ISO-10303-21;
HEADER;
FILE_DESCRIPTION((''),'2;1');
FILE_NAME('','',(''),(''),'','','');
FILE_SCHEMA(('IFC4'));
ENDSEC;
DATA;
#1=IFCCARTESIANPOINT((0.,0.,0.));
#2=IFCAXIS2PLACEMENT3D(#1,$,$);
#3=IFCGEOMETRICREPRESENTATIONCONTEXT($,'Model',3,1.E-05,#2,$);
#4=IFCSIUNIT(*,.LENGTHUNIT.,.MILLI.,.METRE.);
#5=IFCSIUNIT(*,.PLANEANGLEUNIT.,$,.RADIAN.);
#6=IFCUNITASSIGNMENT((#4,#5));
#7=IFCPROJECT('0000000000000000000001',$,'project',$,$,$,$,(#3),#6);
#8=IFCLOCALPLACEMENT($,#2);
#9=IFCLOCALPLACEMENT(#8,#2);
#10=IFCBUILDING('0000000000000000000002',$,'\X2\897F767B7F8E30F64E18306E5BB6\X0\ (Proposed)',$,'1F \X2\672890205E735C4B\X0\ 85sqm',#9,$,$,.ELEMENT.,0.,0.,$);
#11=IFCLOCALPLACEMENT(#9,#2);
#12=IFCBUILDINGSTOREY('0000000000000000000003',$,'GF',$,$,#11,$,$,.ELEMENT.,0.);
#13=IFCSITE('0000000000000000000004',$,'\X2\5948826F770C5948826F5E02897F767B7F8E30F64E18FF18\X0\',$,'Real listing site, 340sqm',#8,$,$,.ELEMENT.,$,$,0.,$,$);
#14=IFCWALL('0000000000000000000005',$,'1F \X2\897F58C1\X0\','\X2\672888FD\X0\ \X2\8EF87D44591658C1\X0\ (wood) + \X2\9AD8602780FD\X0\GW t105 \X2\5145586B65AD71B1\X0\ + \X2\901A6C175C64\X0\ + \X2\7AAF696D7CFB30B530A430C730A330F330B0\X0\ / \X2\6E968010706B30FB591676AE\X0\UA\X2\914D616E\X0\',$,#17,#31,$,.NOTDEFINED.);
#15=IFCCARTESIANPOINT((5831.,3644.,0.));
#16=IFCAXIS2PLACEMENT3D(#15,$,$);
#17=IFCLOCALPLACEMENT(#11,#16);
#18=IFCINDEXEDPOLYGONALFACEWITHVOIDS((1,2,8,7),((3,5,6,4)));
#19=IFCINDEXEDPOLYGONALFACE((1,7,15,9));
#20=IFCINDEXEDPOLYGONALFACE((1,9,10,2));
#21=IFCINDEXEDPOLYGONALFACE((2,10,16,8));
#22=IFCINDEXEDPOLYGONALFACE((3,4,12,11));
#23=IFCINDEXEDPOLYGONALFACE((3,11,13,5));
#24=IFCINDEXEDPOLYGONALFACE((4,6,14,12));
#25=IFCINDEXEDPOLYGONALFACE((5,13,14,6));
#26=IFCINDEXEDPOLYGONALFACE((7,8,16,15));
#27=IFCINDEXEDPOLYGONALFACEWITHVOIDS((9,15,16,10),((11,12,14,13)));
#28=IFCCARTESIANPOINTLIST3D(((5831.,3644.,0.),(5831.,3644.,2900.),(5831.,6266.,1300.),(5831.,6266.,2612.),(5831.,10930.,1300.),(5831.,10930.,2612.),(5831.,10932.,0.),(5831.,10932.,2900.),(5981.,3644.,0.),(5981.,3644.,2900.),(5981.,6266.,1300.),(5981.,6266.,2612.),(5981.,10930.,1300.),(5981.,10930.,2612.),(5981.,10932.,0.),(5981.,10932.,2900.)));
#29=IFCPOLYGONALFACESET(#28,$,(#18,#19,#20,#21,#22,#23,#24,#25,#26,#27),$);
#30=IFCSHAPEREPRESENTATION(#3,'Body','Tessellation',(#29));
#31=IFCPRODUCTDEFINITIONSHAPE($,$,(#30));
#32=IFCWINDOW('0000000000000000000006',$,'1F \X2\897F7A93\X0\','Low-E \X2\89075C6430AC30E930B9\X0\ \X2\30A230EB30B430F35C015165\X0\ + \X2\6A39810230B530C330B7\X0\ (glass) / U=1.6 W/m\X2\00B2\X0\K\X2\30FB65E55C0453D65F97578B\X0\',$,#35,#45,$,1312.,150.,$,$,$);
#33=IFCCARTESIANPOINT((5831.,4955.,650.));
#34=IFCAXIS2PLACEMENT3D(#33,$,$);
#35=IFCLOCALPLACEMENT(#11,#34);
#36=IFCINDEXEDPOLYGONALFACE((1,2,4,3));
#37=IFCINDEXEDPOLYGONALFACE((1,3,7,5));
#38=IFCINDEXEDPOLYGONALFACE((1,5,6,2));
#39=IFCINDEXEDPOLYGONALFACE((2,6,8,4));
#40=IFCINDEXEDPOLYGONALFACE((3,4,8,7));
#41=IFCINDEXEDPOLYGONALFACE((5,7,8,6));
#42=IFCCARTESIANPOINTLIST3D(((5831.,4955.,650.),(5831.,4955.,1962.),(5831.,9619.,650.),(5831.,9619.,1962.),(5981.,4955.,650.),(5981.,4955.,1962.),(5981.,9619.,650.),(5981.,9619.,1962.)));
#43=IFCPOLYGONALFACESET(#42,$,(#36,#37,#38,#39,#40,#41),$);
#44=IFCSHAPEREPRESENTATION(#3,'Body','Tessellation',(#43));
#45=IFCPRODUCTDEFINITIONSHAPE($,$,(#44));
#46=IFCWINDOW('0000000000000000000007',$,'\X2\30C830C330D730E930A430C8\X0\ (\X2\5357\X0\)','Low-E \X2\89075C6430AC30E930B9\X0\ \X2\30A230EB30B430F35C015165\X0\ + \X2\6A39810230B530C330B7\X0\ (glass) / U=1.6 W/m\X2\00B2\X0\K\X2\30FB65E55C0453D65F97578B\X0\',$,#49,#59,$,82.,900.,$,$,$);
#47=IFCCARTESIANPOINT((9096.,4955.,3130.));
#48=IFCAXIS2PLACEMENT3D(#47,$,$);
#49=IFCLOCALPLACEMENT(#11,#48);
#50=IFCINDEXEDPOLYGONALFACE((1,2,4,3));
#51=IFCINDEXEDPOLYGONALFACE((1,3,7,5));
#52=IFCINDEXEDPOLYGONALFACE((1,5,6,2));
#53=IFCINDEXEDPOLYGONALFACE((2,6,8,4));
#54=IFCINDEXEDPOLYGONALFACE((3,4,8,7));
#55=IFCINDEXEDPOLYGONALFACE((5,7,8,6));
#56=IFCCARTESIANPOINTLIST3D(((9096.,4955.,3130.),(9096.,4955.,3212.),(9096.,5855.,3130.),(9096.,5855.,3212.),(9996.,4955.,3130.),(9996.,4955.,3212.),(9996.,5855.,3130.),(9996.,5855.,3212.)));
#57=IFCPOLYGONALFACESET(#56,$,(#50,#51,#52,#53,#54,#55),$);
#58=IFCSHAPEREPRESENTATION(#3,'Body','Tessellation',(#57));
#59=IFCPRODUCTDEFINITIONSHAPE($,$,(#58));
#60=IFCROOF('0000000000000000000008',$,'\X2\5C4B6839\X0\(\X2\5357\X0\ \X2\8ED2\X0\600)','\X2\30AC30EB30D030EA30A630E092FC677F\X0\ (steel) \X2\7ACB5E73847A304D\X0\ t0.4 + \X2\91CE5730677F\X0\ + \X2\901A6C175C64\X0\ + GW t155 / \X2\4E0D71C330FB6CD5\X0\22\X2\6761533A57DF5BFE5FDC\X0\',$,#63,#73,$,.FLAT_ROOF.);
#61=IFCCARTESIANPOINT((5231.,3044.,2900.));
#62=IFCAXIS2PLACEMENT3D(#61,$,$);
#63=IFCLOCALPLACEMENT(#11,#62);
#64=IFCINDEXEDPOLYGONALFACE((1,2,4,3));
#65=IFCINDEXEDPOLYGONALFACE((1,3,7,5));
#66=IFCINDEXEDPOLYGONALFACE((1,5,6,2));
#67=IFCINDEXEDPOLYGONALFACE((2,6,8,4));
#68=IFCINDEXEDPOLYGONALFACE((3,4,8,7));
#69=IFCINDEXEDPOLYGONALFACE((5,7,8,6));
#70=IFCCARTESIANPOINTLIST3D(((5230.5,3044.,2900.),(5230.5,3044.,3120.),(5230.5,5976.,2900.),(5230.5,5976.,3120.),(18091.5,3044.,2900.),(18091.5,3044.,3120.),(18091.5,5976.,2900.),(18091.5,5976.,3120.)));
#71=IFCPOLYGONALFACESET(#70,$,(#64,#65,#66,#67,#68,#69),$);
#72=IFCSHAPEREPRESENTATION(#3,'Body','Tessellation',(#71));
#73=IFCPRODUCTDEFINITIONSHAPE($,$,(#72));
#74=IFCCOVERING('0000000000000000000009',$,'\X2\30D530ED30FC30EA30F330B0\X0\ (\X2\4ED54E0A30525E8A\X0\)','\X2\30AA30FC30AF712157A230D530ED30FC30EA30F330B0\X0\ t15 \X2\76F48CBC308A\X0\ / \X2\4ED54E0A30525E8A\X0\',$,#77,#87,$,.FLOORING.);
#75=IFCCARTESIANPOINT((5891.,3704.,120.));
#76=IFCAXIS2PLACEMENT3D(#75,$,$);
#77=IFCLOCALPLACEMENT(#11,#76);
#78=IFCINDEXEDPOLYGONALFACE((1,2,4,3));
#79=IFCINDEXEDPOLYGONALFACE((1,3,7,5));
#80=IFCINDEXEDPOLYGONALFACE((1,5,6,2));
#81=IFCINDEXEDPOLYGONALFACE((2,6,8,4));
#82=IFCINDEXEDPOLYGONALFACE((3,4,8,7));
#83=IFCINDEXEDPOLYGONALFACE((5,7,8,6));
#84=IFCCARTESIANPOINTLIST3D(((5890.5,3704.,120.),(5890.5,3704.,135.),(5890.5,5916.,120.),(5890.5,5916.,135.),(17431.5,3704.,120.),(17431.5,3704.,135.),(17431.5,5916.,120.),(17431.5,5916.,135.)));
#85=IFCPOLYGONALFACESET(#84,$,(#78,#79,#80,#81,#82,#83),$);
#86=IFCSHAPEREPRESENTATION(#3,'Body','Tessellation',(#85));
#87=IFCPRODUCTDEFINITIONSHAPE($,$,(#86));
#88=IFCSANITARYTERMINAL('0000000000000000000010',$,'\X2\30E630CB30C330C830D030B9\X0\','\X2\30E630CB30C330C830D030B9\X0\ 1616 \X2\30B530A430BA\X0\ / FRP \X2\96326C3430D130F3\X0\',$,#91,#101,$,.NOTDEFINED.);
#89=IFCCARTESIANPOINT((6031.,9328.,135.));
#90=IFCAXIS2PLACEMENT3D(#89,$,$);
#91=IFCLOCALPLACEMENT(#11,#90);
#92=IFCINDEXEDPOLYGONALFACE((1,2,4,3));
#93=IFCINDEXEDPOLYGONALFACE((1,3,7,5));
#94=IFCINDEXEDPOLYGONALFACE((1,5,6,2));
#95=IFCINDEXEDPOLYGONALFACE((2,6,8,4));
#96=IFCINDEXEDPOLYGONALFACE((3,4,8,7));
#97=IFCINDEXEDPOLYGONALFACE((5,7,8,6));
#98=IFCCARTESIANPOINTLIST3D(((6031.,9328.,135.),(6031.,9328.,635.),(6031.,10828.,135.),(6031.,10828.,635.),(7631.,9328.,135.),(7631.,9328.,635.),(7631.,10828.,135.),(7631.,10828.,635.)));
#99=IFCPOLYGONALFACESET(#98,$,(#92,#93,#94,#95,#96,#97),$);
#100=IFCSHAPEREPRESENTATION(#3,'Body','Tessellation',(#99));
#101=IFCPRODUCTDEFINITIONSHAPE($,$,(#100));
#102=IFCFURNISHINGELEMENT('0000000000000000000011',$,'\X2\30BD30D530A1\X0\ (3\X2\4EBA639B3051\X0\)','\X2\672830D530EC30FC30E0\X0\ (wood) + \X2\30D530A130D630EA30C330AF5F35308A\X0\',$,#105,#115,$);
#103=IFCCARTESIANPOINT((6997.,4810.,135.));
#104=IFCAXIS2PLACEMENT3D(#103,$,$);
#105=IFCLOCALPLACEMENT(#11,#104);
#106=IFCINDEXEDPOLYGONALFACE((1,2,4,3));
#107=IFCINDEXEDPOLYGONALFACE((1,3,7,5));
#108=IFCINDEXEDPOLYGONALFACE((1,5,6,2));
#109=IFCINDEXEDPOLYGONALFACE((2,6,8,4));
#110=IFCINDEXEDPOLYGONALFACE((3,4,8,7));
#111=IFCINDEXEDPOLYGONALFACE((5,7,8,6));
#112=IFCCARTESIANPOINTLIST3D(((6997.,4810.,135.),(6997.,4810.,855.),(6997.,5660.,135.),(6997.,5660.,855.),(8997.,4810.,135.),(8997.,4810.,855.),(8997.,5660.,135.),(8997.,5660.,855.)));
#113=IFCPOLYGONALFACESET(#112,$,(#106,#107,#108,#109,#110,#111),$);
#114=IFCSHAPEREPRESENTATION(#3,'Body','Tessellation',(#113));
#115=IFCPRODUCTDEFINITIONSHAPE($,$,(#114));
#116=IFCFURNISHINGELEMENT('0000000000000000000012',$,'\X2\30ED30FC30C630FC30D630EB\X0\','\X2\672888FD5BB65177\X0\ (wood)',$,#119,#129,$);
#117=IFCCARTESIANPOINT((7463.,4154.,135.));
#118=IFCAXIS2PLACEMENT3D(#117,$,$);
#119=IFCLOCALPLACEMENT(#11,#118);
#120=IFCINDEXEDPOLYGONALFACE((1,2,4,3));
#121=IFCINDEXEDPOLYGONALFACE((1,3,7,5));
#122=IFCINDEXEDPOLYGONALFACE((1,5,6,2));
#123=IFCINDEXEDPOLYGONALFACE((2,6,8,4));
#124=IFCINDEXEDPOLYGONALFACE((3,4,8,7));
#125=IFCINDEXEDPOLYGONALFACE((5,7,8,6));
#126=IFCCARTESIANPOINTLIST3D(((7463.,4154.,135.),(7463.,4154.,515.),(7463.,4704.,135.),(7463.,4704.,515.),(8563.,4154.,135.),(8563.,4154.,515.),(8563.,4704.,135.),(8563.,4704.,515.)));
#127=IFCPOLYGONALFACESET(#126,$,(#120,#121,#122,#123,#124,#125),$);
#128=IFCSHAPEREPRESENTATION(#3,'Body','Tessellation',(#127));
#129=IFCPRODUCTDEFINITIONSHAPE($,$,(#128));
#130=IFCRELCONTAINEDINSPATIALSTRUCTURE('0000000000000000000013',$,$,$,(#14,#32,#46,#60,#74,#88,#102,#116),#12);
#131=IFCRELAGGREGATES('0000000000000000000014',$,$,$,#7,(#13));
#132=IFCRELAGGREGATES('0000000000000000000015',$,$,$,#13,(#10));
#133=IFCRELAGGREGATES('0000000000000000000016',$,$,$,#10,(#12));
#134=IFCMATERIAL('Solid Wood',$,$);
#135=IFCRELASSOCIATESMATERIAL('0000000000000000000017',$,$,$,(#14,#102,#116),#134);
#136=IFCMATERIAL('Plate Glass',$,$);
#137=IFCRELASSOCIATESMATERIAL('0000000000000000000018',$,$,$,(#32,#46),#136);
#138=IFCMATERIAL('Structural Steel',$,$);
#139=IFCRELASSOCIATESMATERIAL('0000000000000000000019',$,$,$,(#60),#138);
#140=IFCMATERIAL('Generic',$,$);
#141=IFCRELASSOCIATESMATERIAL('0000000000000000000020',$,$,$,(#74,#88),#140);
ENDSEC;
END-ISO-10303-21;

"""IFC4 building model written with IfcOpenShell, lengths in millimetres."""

from ifc_helpers import new_model, si_unit, frame, frame_2d, origin, place, context, project, spatial, rectangle, extrude, material, element, fill, save


model = new_model("IFC4")

# Units and contexts
model_context = context("Model", 3, precision=1e-05, world=origin())
ifc_project = project(units=[si_unit("LENGTHUNIT", "METRE", prefix="MILLI"), si_unit("PLANEANGLEUNIT", "RADIAN")], contexts=[model_context])

# Site, building, storey
site_placement = place(None, origin())
site = spatial("IfcSite", under=ifc_project, at=site_placement, Name="奈良県奈良市西登美ヶ丘８", ObjectType="Real listing site, 340sqm", CompositionType="ELEMENT", RefElevation=0.0)
building_placement = place(site_placement, origin())
building = spatial("IfcBuilding", under=site, at=building_placement, Name="西登美ヶ丘の家 (Proposed)", ObjectType="1F 木造平屋 85sqm", CompositionType="ELEMENT", ElevationOfRefHeight=0.0, ElevationOfTerrain=0.0)
storey_placement = place(building_placement, origin())
storey = spatial("IfcBuildingStorey", under=building, at=storey_placement, Name="GF", CompositionType="ELEMENT", Elevation=0.0)

# Shared definitions
ifc_material_1 = material(Name="Solid Wood")

# Shared definitions
ifc_material_2 = material(Name="Plate Glass")

# Wall, opening, window
wall_1_placement = place(storey_placement, frame((5831.0, 3644.0, 0.0)))
wall_1 = element("IfcWall", 1, at=wall_1_placement, inside=storey, material=ifc_material_1, Name="1F 西壁", Description="木製 軸組外壁 (wood) + 高性能GW t105 充填断熱 + 通気層 + 窯業系サイディング / 準耐火・外皮UA配慮", PredefinedType="NOTDEFINED", context=model_context, shape_type="SweptSolid", body=[
    extrude(rectangle(XDim=150.0, YDim=7288.0, at=frame_2d((75.0, 3644.0))), frame((5831.0, 3644.0, 0.0)), (0.0, 0.0, 1.0), 2900.0),
])
opening_1_placement = place(storey_placement, frame((5831.0, 4955.0, 650.0)))
opening_1 = element("IfcOpeningElement", 2, at=opening_1_placement, cuts=wall_1, PredefinedType="NOTDEFINED", context=model_context, shape_type="SweptSolid", body=[
    extrude(rectangle(XDim=150.0, YDim=4664.0, at=frame_2d((75.0, 2332.0))), frame((5831.0, 4955.0, 650.0)), (0.0, 0.0, 1.0), 1312.0),
])
window_1_placement = place(storey_placement, frame((5831.0, 4955.0, 650.0)))
window_1 = element("IfcWindow", 3, at=window_1_placement, inside=storey, material=ifc_material_2, Name="1F 西窓", Description="Low-E 複層ガラス アルゴン封入 + 樹脂サッシ (glass) / U=1.6 W/m²K・日射取得型", OverallHeight=1312.0, OverallWidth=150.0, context=model_context, shape_type="SweptSolid", body=[
    extrude(rectangle(XDim=150.0, YDim=4664.0, at=frame_2d((75.0, 2332.0))), frame((5831.0, 4955.0, 650.0)), (0.0, 0.0, 1.0), 1312.0),
])
fill(opening_1, window_1)

# Window
window_2_placement = place(storey_placement, frame((9096.0, 4955.0, 3130.0)))
element("IfcWindow", 4, at=window_2_placement, inside=storey, material=ifc_material_2, Name="トップライト (南)", Description="Low-E 複層ガラス アルゴン封入 + 樹脂サッシ (glass) / U=1.6 W/m²K・日射取得型", OverallHeight=82.0, OverallWidth=900.0, context=model_context, shape_type="SweptSolid", body=[
    extrude(rectangle(XDim=900.0, YDim=900.0, at=frame_2d((450.0, 450.0))), frame((9096.0, 4955.0, 3130.0)), (0.0, 0.0, 1.0), 82.0),
])

# Roof
ifc_material_3 = material(Name="Structural Steel")
roof_1_placement = place(storey_placement, frame((5231.0, 3044.0, 2900.0)))
element("IfcRoof", 5, at=roof_1_placement, inside=storey, material=ifc_material_3, Name="屋根(南 軒600)", Description="ガルバリウム鋼板 (steel) 立平葺き t0.4 + 野地板 + 通気層 + GW t155 / 不燃・法22条区域対応", PredefinedType="FLAT_ROOF", context=model_context, shape_type="SweptSolid", body=[
    extrude(rectangle(XDim=12861.0, YDim=2932.0, at=frame_2d((6430.0, 1466.0))), frame((5231.0, 3044.0, 2900.0)), (0.0, 0.0, 1.0), 220.0),
])

# Covering
ifc_material_4 = material(Name="Generic")
covering_1_placement = place(storey_placement, frame((5891.0, 3704.0, 120.0)))
element("IfcCovering", 6, at=covering_1_placement, inside=storey, material=ifc_material_4, Name="フローリング (仕上げ床)", Description="オーク無垢フローリング t15 直貼り / 仕上げ床", PredefinedType="FLOORING", context=model_context, shape_type="SweptSolid", body=[
    extrude(rectangle(XDim=11541.0, YDim=2212.0, at=frame_2d((5770.0, 1106.0))), frame((5891.0, 3704.0, 120.0)), (0.0, 0.0, 1.0), 15.0),
])

# Sanitary terminal
sanitary_terminal_placement = place(storey_placement, frame((6031.0, 9328.0, 135.0)))
element("IfcSanitaryTerminal", 7, at=sanitary_terminal_placement, inside=storey, material=ifc_material_4, Name="ユニットバス", Description="ユニットバス 1616 サイズ / FRP 防水パン", PredefinedType="NOTDEFINED", context=model_context, shape_type="SweptSolid", body=[
    extrude(rectangle(XDim=1600.0, YDim=1500.0, at=frame_2d((800.0, 750.0))), frame((6031.0, 9328.0, 135.0)), (0.0, 0.0, 1.0), 500.0),
])

# Furnishing elements
furnishing_1_placement = place(storey_placement, frame((6997.0, 4810.0, 135.0)))
element("IfcFurnishingElement", 8, at=furnishing_1_placement, inside=storey, material=ifc_material_1, Name="ソファ (3人掛け)", Description="木フレーム (wood) + ファブリック張り", context=model_context, shape_type="SweptSolid", body=[
    extrude(rectangle(XDim=2000.0, YDim=850.0, at=frame_2d((1000.0, 425.0))), frame((6997.0, 4810.0, 135.0)), (0.0, 0.0, 1.0), 720.0),
])
furnishing_2_placement = place(storey_placement, frame((7463.0, 4154.0, 135.0)))
element("IfcFurnishingElement", 9, at=furnishing_2_placement, inside=storey, material=ifc_material_1, Name="ローテーブル", Description="木製家具 (wood)", context=model_context, shape_type="SweptSolid", body=[
    extrude(rectangle(XDim=1100.0, YDim=550.0, at=frame_2d((550.0, 275.0))), frame((7463.0, 4154.0, 135.0)), (0.0, 0.0, 1.0), 380.0),
])

save(model, "model.ifc")
